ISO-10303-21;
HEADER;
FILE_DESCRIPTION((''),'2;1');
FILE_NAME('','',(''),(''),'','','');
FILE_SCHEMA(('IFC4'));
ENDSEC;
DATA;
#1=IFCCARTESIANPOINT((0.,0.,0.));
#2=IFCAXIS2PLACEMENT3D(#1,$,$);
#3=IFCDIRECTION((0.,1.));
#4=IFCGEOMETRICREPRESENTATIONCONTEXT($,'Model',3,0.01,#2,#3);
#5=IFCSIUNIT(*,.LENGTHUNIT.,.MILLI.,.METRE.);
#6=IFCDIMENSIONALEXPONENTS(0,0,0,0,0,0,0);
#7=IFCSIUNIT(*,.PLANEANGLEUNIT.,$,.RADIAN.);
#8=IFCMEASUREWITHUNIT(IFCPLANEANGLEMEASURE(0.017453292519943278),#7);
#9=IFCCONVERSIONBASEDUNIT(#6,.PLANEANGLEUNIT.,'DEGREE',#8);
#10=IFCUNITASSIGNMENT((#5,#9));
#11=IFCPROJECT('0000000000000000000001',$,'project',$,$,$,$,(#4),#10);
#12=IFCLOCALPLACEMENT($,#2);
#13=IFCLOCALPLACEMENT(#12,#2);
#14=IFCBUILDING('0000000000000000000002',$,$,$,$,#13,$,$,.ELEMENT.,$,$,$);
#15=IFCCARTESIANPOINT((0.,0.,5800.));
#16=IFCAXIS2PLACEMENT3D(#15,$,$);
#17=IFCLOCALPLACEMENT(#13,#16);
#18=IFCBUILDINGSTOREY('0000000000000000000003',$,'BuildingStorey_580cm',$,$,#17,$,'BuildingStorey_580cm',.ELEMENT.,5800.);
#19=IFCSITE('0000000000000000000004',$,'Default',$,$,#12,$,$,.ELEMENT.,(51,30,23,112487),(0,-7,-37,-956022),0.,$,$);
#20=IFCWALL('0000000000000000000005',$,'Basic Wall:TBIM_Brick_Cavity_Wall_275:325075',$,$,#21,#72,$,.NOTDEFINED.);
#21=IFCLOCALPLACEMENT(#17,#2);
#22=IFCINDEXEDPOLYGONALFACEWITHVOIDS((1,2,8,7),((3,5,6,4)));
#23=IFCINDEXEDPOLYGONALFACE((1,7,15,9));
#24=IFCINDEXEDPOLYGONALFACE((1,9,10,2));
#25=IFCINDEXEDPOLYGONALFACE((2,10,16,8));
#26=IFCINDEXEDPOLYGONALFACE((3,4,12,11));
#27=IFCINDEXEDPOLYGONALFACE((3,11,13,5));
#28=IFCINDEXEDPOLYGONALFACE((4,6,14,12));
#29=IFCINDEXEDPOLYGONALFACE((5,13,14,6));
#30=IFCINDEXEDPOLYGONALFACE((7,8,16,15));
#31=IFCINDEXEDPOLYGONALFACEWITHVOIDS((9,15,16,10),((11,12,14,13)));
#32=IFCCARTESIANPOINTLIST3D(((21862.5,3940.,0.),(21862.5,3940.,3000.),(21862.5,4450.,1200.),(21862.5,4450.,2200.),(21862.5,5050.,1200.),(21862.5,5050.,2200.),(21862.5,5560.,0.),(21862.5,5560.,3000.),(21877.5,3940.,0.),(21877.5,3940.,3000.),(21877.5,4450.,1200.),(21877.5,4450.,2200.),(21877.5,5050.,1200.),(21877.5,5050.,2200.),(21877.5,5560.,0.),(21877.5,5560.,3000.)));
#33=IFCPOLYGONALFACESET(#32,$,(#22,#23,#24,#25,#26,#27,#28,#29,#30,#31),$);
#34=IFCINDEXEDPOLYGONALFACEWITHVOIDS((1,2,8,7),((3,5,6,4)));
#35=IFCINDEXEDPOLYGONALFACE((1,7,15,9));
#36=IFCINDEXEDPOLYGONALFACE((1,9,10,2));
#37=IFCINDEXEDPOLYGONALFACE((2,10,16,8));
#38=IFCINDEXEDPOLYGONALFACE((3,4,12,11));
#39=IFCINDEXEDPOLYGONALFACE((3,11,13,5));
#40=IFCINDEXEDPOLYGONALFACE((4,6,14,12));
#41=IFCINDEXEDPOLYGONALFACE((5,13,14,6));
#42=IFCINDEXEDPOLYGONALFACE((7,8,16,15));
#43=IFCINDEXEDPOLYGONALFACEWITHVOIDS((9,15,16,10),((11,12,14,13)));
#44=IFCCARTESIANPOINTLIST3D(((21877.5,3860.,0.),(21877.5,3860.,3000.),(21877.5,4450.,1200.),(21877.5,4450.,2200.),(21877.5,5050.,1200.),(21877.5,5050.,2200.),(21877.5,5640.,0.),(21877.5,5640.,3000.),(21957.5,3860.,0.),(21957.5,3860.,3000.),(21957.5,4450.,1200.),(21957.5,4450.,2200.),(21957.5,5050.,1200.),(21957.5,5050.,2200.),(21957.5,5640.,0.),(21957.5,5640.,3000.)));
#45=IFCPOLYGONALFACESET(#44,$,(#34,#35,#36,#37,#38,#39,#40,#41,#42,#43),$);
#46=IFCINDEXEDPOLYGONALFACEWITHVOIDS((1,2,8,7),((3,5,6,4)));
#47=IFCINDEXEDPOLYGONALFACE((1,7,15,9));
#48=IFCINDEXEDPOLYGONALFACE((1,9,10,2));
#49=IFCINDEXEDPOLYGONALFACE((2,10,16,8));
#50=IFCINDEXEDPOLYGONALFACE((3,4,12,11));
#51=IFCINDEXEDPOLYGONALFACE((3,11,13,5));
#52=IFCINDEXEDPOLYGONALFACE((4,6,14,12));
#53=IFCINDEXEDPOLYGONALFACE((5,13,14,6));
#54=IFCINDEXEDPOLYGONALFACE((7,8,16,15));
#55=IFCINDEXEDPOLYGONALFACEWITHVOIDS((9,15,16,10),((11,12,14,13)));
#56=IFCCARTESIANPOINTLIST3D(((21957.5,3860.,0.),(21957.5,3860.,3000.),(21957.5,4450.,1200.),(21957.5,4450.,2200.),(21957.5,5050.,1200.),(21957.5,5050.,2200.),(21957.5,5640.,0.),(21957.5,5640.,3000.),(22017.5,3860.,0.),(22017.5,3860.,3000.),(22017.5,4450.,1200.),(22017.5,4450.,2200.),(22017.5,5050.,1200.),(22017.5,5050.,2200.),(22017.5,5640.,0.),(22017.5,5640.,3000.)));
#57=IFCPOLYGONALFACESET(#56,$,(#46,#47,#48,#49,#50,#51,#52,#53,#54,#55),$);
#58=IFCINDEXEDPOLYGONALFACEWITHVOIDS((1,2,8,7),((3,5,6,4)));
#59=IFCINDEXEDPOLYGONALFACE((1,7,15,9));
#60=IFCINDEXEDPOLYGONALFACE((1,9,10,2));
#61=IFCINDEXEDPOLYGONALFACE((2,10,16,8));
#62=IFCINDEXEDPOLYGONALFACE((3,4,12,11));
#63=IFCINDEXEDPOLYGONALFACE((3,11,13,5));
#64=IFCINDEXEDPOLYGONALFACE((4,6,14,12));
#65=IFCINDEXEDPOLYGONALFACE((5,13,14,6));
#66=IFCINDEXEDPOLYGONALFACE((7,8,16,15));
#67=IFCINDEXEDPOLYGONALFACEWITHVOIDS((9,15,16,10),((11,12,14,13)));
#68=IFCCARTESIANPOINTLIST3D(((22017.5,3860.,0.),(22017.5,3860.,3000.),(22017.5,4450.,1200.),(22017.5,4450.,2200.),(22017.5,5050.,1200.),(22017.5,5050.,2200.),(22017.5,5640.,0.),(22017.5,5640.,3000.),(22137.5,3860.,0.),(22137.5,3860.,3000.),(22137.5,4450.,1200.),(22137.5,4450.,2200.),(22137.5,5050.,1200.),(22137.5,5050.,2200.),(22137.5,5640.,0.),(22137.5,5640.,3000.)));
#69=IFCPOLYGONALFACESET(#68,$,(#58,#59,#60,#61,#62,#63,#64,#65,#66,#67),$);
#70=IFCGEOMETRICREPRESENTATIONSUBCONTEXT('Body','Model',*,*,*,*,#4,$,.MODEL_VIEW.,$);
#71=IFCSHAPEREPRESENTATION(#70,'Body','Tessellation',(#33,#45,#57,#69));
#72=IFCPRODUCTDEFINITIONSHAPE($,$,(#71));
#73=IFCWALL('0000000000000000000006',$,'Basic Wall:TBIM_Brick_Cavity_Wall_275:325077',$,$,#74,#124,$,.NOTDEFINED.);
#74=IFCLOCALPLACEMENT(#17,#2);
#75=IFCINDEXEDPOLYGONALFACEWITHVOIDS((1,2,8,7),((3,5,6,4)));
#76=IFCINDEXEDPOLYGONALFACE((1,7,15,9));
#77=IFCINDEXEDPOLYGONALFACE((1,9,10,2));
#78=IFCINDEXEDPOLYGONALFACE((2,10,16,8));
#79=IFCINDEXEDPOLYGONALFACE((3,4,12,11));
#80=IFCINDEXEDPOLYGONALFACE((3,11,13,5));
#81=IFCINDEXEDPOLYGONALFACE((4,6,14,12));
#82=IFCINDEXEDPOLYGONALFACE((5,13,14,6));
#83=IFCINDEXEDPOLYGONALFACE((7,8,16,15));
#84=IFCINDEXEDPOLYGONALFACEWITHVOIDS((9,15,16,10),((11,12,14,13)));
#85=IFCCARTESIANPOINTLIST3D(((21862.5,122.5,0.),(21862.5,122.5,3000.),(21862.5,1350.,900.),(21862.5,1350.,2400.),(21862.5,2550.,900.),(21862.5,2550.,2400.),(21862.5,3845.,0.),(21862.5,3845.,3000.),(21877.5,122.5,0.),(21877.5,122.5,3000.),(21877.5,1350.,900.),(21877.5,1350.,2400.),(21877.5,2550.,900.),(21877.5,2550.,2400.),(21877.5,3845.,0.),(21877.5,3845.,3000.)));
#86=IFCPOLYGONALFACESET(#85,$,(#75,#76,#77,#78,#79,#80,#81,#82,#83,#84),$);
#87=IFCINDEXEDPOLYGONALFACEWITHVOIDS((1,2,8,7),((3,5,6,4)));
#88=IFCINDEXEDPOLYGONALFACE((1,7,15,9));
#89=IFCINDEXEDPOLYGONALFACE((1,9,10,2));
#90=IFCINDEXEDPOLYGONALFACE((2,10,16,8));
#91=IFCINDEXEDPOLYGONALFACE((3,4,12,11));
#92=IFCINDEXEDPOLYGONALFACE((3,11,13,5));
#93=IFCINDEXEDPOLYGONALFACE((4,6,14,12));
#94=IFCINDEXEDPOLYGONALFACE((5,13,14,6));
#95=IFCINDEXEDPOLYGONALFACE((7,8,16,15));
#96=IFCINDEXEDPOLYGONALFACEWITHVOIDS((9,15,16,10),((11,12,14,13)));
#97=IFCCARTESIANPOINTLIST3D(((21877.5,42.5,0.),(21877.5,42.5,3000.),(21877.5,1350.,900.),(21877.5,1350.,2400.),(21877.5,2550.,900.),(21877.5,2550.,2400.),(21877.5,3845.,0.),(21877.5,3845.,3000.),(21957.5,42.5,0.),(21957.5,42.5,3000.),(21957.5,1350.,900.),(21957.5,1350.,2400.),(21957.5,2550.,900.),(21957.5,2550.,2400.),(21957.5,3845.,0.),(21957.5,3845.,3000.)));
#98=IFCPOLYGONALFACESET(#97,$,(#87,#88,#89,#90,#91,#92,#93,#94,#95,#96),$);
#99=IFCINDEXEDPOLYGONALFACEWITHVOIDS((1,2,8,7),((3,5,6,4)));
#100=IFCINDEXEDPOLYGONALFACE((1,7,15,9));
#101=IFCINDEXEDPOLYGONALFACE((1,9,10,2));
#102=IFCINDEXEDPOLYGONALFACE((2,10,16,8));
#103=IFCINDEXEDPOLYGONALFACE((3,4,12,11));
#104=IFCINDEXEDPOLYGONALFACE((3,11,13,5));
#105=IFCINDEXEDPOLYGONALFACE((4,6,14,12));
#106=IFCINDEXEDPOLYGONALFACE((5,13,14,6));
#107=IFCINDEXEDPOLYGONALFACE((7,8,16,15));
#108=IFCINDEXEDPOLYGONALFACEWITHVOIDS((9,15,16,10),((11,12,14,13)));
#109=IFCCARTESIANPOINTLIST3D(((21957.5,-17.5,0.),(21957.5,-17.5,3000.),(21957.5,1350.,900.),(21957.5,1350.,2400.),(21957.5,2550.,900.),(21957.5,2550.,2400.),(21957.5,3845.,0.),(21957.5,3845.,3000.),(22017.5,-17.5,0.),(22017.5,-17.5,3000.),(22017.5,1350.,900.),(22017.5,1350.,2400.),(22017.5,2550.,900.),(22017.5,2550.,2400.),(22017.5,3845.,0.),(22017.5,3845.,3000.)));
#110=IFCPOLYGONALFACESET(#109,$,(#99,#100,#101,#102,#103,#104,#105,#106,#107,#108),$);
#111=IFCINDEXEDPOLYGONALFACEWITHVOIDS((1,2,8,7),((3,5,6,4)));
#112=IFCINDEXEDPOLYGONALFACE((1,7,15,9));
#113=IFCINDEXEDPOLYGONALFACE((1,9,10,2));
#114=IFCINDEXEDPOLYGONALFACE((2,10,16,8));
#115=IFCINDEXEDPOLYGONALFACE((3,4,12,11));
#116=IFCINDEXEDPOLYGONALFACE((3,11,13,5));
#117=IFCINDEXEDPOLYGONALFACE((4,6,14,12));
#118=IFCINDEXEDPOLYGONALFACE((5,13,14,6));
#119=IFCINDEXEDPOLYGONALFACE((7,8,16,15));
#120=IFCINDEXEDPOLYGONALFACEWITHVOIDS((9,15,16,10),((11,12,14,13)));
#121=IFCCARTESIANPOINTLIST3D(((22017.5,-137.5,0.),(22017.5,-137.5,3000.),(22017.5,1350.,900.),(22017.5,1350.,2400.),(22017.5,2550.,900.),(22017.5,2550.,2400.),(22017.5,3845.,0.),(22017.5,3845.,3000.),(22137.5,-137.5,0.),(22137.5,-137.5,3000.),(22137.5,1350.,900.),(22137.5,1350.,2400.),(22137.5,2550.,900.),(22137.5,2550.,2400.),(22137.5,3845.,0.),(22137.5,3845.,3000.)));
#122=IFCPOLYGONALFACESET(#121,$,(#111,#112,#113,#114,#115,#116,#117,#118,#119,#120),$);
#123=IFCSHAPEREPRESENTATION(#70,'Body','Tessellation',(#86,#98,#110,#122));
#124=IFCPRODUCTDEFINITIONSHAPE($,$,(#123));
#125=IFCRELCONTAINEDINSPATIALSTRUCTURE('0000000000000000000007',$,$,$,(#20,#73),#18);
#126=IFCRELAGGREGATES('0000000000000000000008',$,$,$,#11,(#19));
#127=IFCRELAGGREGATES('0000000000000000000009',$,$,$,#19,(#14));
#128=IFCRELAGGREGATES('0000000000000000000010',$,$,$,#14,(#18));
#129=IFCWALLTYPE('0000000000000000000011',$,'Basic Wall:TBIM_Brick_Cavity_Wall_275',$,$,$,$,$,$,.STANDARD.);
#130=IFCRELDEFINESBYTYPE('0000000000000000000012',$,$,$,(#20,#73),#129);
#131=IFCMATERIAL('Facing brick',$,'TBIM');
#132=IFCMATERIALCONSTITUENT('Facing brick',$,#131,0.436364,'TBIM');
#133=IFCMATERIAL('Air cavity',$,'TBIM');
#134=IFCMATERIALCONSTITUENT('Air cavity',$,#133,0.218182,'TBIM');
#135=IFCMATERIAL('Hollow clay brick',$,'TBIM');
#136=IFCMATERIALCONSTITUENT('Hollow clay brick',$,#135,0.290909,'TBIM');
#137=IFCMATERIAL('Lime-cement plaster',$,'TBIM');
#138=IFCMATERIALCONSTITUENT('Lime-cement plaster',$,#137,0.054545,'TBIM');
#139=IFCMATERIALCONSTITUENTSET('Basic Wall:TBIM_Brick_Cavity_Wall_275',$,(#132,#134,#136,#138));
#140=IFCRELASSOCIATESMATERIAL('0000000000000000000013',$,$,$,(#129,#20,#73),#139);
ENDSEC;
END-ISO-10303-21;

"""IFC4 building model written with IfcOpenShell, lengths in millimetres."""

from ifc_helpers import new_model, entity, si_unit, converted_unit, direction, frame, origin, place, context, subcontext, project, spatial, indexed_curve, outline, extrude, material, constituent, constituent_set, type_object, element, save


model = new_model("IFC4")

# Units and contexts
model_context = context("Model", 3, precision=0.01, world=origin(), true_north=direction((0.0, 1.0)))
body_context = subcontext(model_context, "Body", "Model", "MODEL_VIEW")
ifc_project = project(units=[si_unit("LENGTHUNIT", "METRE", prefix="MILLI"), converted_unit("PLANEANGLEUNIT", "DEGREE", entity("IfcPlaneAngleMeasure", 0.017453292519943278), si_unit("PLANEANGLEUNIT", "RADIAN"), dimensions=[0, 0, 0, 0, 0, 0, 0])], contexts=[model_context])

# Site, building, storey
site_placement = place(None, origin())
site = spatial("IfcSite", under=ifc_project, at=site_placement, Name="Default", CompositionType="ELEMENT", RefLatitude=(51, 30, 23, 112487), RefLongitude=(0, -7, -37, -956022), RefElevation=0.0)
building_placement = place(site_placement, origin())
building = spatial("IfcBuilding", under=site, at=building_placement, CompositionType="ELEMENT")
storey_placement = place(building_placement, frame((0.0, 0.0, 5800.0)))
storey = spatial("IfcBuildingStorey", under=building, at=storey_placement, Name="BuildingStorey_580cm", LongName="BuildingStorey_580cm", CompositionType="ELEMENT", Elevation=5800.0)

# Walls, openings
ifc_material_1 = material(Name="Facing brick", Category="TBIM")
ifc_constituent_1 = constituent(ifc_material_1, Name="Facing brick", Category="TBIM", fraction=0.436364)
ifc_material_2 = material(Name="Air cavity", Category="TBIM")
ifc_constituent_2 = constituent(ifc_material_2, Name="Air cavity", Category="TBIM", fraction=0.218182)
ifc_material_3 = material(Name="Hollow clay brick", Category="TBIM")
ifc_constituent_3 = constituent(ifc_material_3, Name="Hollow clay brick", Category="TBIM", fraction=0.290909)
ifc_material_4 = material(Name="Lime-cement plaster", Category="TBIM")
ifc_constituent_4 = constituent(ifc_material_4, Name="Lime-cement plaster", Category="TBIM", fraction=0.054545)
ifc_constituent_set_1 = constituent_set(constituents=[ifc_constituent_1, ifc_constituent_2, ifc_constituent_3, ifc_constituent_4], Name="Basic Wall:TBIM_Brick_Cavity_Wall_275")
wall_type_1 = type_object("IfcWallType", Name="Basic Wall:TBIM_Brick_Cavity_Wall_275", PredefinedType="STANDARD", material=ifc_constituent_set_1)
wall_1_placement = place(storey_placement, frame((22000.0, 5655.0, 0.0), z_axis=(0.0, 0.0, 1.0), x_axis=(0.0, -1.0, 0.0)))
wall_1 = element("IfcWall", 1, at=wall_1_placement, inside=storey, type_object=wall_type_1, material=ifc_constituent_set_1, Name="Basic Wall:TBIM_Brick_Cavity_Wall_275:325075", PredefinedType="NOTDEFINED", context=body_context, shape_type="SweptSolid", body=[
    extrude(outline(indexed_curve([(-1500.0, -810.0), (1500.0, -810.0), (1500.0, -795.0), (1500.0, 795.0), (1500.0, 810.0), (-1500.0, 810.0), (-1500.0, 795.0), (-1500.0, -795.0), (-1500.0, -810.0)], self_intersect=False), holes=[indexed_curve([(700.0, -300.0), (-300.0, -300.0), (-300.0, 300.0), (700.0, 300.0), (700.0, -300.0)], self_intersect=False)]), frame((905.0, -137.5, 1500.0), z_axis=(0.0, 1.0, 0.0), x_axis=(0.0, 0.0, 1.0)), (0.0, 0.0, 1.0), 15.0),
    extrude(outline(indexed_curve([(-1500.0, -890.0), (1500.0, -890.0), (1500.0, 890.0), (-1500.0, 890.0), (-1500.0, -890.0)], self_intersect=False), holes=[indexed_curve([(-300.0, -300.0), (-300.0, 300.0), (700.0, 300.0), (700.0, -300.0), (-300.0, -300.0)], self_intersect=False)]), frame((905.0, -122.5, 1500.0), z_axis=(0.0, 1.0, 0.0), x_axis=(0.0, 0.0, 1.0)), (0.0, 0.0, 1.0), 80.0),
    extrude(outline(indexed_curve([(-1500.0, -890.0), (1500.0, -890.0), (1500.0, 890.0), (-1500.0, 890.0), (-1500.0, -890.0)], self_intersect=False), holes=[indexed_curve([(-300.0, -300.0), (-300.0, 300.0), (700.0, 300.0), (700.0, -300.0), (-300.0, -300.0)], self_intersect=False)]), frame((905.0, -42.5, 1500.0), z_axis=(0.0, 1.0, 0.0), x_axis=(0.0, 0.0, 1.0)), (0.0, 0.0, 1.0), 60.0),
    extrude(outline(indexed_curve([(-1500.0, -890.0), (1500.0, -890.0), (1500.0, 890.0), (-1500.0, 890.0), (-1500.0, -890.0)], self_intersect=False), holes=[indexed_curve([(-300.0, -300.0), (-300.0, 300.0), (700.0, 300.0), (700.0, -300.0), (-300.0, -300.0)], self_intersect=False)]), frame((905.0, 17.5, 1500.0), z_axis=(0.0, 1.0, 0.0), x_axis=(0.0, 0.0, 1.0)), (0.0, 0.0, 1.0), 120.0),
])
opening_1_placement = place(wall_1_placement, frame((605.0, -137.5, 1200.0)))
element("IfcOpeningElement", 2, at=opening_1_placement, cuts=wall_1, PredefinedType="OPENING", context=body_context, shape_type="SweptSolid", body=[
    extrude(outline(indexed_curve([(1000.0, 0.0), (1000.0, 600.0), (0.0, 600.0), (0.0, 0.0), (1000.0, 0.0)], self_intersect=False)), frame((0.0, 0.0, 0.0), z_axis=(0.0, 1.0, 0.0), x_axis=(0.0, 0.0, 1.0)), (0.0, 0.0, 1.0), 275.0),
])
wall_2_placement = place(storey_placement, frame((22000.0, -137.5, 0.0), z_axis=(0.0, 0.0, 1.0), x_axis=(0.0, 1.0, 0.0)))
wall_2 = element("IfcWall", 3, at=wall_2_placement, inside=storey, type_object=wall_type_1, material=ifc_constituent_set_1, Name="Basic Wall:TBIM_Brick_Cavity_Wall_275:325077", PredefinedType="NOTDEFINED", context=body_context, shape_type="SweptSolid", body=[
    extrude(outline(indexed_curve([(-1245.8, -1500.0), (-1230.8, -1500.0), (2476.7, -1500.0), (2476.7, 1500.0), (-1230.8, 1500.0), (-1245.8, 1500.0), (-1245.8, -1500.0)], self_intersect=False), holes=[indexed_curve([(-18.3, 900.0), (1181.7, 900.0), (1181.7, -600.0), (-18.3, -600.0), (-18.3, 900.0)], self_intersect=False)]), frame((1505.8, 137.5, 1500.0), z_axis=(0.0, -1.0, 0.0), x_axis=(1.0, 0.0, 0.0)), (0.0, 0.0, 1.0), 15.0),
    extrude(outline(indexed_curve([(-1500.0, -1901.3), (1500.0, -1901.3), (1500.0, 1901.3), (-1500.0, 1901.3), (-1500.0, -1901.3)], self_intersect=False), holes=[indexed_curve([(900.0, 593.8), (900.0, -606.2), (-600.0, -606.2), (-600.0, 593.8), (900.0, 593.8)], self_intersect=False)]), frame((2081.3, 122.5, 1500.0), z_axis=(0.0, -1.0, 0.0), x_axis=(0.0, 0.0, 1.0)), (0.0, 0.0, 1.0), 80.0),
    extrude(outline(indexed_curve([(-1500.0, -1931.3), (1500.0, -1931.3), (1500.0, 1931.3), (-1500.0, 1931.2), (-1500.0, -1931.3)], self_intersect=False), holes=[indexed_curve([(900.0, 563.8), (900.0, -636.2), (-600.0, -636.2), (-600.0, 563.8), (900.0, 563.8)], self_intersect=False)]), frame((2051.3, 42.5, 1500.0), z_axis=(0.0, -1.0, 0.0), x_axis=(0.0, 0.0, 1.0)), (0.0, 0.0, 1.0), 60.0),
    extrude(outline(indexed_curve([(-1500.0, -1991.3), (1500.0, -1991.3), (1500.0, 1991.3), (-1500.0, 1991.3), (-1500.0, -1991.3)], self_intersect=False), holes=[indexed_curve([(900.0, 503.8), (900.0, -696.2), (-600.0, -696.2), (-600.0, 503.8), (900.0, 503.8)], self_intersect=False)]), frame((1991.3, -17.5, 1500.0), z_axis=(0.0, -1.0, 0.0), x_axis=(0.0, 0.0, 1.0)), (0.0, 0.0, 1.0), 120.0),
])
opening_2_placement = place(wall_2_placement, frame((1487.5, -137.5, 900.0)))
element("IfcOpeningElement", 4, at=opening_2_placement, cuts=wall_2, PredefinedType="OPENING", context=body_context, shape_type="SweptSolid", body=[
    extrude(outline(indexed_curve([(1500.0, 0.0), (1500.0, 1200.0), (0.0, 1200.0), (0.0, 0.0), (1500.0, 0.0)], self_intersect=False)), frame((0.0, 0.0, 0.0), z_axis=(0.0, 1.0, 0.0), x_axis=(0.0, 0.0, 1.0)), (0.0, 0.0, 1.0), 275.0),
])

save(model, "model.ifc")
